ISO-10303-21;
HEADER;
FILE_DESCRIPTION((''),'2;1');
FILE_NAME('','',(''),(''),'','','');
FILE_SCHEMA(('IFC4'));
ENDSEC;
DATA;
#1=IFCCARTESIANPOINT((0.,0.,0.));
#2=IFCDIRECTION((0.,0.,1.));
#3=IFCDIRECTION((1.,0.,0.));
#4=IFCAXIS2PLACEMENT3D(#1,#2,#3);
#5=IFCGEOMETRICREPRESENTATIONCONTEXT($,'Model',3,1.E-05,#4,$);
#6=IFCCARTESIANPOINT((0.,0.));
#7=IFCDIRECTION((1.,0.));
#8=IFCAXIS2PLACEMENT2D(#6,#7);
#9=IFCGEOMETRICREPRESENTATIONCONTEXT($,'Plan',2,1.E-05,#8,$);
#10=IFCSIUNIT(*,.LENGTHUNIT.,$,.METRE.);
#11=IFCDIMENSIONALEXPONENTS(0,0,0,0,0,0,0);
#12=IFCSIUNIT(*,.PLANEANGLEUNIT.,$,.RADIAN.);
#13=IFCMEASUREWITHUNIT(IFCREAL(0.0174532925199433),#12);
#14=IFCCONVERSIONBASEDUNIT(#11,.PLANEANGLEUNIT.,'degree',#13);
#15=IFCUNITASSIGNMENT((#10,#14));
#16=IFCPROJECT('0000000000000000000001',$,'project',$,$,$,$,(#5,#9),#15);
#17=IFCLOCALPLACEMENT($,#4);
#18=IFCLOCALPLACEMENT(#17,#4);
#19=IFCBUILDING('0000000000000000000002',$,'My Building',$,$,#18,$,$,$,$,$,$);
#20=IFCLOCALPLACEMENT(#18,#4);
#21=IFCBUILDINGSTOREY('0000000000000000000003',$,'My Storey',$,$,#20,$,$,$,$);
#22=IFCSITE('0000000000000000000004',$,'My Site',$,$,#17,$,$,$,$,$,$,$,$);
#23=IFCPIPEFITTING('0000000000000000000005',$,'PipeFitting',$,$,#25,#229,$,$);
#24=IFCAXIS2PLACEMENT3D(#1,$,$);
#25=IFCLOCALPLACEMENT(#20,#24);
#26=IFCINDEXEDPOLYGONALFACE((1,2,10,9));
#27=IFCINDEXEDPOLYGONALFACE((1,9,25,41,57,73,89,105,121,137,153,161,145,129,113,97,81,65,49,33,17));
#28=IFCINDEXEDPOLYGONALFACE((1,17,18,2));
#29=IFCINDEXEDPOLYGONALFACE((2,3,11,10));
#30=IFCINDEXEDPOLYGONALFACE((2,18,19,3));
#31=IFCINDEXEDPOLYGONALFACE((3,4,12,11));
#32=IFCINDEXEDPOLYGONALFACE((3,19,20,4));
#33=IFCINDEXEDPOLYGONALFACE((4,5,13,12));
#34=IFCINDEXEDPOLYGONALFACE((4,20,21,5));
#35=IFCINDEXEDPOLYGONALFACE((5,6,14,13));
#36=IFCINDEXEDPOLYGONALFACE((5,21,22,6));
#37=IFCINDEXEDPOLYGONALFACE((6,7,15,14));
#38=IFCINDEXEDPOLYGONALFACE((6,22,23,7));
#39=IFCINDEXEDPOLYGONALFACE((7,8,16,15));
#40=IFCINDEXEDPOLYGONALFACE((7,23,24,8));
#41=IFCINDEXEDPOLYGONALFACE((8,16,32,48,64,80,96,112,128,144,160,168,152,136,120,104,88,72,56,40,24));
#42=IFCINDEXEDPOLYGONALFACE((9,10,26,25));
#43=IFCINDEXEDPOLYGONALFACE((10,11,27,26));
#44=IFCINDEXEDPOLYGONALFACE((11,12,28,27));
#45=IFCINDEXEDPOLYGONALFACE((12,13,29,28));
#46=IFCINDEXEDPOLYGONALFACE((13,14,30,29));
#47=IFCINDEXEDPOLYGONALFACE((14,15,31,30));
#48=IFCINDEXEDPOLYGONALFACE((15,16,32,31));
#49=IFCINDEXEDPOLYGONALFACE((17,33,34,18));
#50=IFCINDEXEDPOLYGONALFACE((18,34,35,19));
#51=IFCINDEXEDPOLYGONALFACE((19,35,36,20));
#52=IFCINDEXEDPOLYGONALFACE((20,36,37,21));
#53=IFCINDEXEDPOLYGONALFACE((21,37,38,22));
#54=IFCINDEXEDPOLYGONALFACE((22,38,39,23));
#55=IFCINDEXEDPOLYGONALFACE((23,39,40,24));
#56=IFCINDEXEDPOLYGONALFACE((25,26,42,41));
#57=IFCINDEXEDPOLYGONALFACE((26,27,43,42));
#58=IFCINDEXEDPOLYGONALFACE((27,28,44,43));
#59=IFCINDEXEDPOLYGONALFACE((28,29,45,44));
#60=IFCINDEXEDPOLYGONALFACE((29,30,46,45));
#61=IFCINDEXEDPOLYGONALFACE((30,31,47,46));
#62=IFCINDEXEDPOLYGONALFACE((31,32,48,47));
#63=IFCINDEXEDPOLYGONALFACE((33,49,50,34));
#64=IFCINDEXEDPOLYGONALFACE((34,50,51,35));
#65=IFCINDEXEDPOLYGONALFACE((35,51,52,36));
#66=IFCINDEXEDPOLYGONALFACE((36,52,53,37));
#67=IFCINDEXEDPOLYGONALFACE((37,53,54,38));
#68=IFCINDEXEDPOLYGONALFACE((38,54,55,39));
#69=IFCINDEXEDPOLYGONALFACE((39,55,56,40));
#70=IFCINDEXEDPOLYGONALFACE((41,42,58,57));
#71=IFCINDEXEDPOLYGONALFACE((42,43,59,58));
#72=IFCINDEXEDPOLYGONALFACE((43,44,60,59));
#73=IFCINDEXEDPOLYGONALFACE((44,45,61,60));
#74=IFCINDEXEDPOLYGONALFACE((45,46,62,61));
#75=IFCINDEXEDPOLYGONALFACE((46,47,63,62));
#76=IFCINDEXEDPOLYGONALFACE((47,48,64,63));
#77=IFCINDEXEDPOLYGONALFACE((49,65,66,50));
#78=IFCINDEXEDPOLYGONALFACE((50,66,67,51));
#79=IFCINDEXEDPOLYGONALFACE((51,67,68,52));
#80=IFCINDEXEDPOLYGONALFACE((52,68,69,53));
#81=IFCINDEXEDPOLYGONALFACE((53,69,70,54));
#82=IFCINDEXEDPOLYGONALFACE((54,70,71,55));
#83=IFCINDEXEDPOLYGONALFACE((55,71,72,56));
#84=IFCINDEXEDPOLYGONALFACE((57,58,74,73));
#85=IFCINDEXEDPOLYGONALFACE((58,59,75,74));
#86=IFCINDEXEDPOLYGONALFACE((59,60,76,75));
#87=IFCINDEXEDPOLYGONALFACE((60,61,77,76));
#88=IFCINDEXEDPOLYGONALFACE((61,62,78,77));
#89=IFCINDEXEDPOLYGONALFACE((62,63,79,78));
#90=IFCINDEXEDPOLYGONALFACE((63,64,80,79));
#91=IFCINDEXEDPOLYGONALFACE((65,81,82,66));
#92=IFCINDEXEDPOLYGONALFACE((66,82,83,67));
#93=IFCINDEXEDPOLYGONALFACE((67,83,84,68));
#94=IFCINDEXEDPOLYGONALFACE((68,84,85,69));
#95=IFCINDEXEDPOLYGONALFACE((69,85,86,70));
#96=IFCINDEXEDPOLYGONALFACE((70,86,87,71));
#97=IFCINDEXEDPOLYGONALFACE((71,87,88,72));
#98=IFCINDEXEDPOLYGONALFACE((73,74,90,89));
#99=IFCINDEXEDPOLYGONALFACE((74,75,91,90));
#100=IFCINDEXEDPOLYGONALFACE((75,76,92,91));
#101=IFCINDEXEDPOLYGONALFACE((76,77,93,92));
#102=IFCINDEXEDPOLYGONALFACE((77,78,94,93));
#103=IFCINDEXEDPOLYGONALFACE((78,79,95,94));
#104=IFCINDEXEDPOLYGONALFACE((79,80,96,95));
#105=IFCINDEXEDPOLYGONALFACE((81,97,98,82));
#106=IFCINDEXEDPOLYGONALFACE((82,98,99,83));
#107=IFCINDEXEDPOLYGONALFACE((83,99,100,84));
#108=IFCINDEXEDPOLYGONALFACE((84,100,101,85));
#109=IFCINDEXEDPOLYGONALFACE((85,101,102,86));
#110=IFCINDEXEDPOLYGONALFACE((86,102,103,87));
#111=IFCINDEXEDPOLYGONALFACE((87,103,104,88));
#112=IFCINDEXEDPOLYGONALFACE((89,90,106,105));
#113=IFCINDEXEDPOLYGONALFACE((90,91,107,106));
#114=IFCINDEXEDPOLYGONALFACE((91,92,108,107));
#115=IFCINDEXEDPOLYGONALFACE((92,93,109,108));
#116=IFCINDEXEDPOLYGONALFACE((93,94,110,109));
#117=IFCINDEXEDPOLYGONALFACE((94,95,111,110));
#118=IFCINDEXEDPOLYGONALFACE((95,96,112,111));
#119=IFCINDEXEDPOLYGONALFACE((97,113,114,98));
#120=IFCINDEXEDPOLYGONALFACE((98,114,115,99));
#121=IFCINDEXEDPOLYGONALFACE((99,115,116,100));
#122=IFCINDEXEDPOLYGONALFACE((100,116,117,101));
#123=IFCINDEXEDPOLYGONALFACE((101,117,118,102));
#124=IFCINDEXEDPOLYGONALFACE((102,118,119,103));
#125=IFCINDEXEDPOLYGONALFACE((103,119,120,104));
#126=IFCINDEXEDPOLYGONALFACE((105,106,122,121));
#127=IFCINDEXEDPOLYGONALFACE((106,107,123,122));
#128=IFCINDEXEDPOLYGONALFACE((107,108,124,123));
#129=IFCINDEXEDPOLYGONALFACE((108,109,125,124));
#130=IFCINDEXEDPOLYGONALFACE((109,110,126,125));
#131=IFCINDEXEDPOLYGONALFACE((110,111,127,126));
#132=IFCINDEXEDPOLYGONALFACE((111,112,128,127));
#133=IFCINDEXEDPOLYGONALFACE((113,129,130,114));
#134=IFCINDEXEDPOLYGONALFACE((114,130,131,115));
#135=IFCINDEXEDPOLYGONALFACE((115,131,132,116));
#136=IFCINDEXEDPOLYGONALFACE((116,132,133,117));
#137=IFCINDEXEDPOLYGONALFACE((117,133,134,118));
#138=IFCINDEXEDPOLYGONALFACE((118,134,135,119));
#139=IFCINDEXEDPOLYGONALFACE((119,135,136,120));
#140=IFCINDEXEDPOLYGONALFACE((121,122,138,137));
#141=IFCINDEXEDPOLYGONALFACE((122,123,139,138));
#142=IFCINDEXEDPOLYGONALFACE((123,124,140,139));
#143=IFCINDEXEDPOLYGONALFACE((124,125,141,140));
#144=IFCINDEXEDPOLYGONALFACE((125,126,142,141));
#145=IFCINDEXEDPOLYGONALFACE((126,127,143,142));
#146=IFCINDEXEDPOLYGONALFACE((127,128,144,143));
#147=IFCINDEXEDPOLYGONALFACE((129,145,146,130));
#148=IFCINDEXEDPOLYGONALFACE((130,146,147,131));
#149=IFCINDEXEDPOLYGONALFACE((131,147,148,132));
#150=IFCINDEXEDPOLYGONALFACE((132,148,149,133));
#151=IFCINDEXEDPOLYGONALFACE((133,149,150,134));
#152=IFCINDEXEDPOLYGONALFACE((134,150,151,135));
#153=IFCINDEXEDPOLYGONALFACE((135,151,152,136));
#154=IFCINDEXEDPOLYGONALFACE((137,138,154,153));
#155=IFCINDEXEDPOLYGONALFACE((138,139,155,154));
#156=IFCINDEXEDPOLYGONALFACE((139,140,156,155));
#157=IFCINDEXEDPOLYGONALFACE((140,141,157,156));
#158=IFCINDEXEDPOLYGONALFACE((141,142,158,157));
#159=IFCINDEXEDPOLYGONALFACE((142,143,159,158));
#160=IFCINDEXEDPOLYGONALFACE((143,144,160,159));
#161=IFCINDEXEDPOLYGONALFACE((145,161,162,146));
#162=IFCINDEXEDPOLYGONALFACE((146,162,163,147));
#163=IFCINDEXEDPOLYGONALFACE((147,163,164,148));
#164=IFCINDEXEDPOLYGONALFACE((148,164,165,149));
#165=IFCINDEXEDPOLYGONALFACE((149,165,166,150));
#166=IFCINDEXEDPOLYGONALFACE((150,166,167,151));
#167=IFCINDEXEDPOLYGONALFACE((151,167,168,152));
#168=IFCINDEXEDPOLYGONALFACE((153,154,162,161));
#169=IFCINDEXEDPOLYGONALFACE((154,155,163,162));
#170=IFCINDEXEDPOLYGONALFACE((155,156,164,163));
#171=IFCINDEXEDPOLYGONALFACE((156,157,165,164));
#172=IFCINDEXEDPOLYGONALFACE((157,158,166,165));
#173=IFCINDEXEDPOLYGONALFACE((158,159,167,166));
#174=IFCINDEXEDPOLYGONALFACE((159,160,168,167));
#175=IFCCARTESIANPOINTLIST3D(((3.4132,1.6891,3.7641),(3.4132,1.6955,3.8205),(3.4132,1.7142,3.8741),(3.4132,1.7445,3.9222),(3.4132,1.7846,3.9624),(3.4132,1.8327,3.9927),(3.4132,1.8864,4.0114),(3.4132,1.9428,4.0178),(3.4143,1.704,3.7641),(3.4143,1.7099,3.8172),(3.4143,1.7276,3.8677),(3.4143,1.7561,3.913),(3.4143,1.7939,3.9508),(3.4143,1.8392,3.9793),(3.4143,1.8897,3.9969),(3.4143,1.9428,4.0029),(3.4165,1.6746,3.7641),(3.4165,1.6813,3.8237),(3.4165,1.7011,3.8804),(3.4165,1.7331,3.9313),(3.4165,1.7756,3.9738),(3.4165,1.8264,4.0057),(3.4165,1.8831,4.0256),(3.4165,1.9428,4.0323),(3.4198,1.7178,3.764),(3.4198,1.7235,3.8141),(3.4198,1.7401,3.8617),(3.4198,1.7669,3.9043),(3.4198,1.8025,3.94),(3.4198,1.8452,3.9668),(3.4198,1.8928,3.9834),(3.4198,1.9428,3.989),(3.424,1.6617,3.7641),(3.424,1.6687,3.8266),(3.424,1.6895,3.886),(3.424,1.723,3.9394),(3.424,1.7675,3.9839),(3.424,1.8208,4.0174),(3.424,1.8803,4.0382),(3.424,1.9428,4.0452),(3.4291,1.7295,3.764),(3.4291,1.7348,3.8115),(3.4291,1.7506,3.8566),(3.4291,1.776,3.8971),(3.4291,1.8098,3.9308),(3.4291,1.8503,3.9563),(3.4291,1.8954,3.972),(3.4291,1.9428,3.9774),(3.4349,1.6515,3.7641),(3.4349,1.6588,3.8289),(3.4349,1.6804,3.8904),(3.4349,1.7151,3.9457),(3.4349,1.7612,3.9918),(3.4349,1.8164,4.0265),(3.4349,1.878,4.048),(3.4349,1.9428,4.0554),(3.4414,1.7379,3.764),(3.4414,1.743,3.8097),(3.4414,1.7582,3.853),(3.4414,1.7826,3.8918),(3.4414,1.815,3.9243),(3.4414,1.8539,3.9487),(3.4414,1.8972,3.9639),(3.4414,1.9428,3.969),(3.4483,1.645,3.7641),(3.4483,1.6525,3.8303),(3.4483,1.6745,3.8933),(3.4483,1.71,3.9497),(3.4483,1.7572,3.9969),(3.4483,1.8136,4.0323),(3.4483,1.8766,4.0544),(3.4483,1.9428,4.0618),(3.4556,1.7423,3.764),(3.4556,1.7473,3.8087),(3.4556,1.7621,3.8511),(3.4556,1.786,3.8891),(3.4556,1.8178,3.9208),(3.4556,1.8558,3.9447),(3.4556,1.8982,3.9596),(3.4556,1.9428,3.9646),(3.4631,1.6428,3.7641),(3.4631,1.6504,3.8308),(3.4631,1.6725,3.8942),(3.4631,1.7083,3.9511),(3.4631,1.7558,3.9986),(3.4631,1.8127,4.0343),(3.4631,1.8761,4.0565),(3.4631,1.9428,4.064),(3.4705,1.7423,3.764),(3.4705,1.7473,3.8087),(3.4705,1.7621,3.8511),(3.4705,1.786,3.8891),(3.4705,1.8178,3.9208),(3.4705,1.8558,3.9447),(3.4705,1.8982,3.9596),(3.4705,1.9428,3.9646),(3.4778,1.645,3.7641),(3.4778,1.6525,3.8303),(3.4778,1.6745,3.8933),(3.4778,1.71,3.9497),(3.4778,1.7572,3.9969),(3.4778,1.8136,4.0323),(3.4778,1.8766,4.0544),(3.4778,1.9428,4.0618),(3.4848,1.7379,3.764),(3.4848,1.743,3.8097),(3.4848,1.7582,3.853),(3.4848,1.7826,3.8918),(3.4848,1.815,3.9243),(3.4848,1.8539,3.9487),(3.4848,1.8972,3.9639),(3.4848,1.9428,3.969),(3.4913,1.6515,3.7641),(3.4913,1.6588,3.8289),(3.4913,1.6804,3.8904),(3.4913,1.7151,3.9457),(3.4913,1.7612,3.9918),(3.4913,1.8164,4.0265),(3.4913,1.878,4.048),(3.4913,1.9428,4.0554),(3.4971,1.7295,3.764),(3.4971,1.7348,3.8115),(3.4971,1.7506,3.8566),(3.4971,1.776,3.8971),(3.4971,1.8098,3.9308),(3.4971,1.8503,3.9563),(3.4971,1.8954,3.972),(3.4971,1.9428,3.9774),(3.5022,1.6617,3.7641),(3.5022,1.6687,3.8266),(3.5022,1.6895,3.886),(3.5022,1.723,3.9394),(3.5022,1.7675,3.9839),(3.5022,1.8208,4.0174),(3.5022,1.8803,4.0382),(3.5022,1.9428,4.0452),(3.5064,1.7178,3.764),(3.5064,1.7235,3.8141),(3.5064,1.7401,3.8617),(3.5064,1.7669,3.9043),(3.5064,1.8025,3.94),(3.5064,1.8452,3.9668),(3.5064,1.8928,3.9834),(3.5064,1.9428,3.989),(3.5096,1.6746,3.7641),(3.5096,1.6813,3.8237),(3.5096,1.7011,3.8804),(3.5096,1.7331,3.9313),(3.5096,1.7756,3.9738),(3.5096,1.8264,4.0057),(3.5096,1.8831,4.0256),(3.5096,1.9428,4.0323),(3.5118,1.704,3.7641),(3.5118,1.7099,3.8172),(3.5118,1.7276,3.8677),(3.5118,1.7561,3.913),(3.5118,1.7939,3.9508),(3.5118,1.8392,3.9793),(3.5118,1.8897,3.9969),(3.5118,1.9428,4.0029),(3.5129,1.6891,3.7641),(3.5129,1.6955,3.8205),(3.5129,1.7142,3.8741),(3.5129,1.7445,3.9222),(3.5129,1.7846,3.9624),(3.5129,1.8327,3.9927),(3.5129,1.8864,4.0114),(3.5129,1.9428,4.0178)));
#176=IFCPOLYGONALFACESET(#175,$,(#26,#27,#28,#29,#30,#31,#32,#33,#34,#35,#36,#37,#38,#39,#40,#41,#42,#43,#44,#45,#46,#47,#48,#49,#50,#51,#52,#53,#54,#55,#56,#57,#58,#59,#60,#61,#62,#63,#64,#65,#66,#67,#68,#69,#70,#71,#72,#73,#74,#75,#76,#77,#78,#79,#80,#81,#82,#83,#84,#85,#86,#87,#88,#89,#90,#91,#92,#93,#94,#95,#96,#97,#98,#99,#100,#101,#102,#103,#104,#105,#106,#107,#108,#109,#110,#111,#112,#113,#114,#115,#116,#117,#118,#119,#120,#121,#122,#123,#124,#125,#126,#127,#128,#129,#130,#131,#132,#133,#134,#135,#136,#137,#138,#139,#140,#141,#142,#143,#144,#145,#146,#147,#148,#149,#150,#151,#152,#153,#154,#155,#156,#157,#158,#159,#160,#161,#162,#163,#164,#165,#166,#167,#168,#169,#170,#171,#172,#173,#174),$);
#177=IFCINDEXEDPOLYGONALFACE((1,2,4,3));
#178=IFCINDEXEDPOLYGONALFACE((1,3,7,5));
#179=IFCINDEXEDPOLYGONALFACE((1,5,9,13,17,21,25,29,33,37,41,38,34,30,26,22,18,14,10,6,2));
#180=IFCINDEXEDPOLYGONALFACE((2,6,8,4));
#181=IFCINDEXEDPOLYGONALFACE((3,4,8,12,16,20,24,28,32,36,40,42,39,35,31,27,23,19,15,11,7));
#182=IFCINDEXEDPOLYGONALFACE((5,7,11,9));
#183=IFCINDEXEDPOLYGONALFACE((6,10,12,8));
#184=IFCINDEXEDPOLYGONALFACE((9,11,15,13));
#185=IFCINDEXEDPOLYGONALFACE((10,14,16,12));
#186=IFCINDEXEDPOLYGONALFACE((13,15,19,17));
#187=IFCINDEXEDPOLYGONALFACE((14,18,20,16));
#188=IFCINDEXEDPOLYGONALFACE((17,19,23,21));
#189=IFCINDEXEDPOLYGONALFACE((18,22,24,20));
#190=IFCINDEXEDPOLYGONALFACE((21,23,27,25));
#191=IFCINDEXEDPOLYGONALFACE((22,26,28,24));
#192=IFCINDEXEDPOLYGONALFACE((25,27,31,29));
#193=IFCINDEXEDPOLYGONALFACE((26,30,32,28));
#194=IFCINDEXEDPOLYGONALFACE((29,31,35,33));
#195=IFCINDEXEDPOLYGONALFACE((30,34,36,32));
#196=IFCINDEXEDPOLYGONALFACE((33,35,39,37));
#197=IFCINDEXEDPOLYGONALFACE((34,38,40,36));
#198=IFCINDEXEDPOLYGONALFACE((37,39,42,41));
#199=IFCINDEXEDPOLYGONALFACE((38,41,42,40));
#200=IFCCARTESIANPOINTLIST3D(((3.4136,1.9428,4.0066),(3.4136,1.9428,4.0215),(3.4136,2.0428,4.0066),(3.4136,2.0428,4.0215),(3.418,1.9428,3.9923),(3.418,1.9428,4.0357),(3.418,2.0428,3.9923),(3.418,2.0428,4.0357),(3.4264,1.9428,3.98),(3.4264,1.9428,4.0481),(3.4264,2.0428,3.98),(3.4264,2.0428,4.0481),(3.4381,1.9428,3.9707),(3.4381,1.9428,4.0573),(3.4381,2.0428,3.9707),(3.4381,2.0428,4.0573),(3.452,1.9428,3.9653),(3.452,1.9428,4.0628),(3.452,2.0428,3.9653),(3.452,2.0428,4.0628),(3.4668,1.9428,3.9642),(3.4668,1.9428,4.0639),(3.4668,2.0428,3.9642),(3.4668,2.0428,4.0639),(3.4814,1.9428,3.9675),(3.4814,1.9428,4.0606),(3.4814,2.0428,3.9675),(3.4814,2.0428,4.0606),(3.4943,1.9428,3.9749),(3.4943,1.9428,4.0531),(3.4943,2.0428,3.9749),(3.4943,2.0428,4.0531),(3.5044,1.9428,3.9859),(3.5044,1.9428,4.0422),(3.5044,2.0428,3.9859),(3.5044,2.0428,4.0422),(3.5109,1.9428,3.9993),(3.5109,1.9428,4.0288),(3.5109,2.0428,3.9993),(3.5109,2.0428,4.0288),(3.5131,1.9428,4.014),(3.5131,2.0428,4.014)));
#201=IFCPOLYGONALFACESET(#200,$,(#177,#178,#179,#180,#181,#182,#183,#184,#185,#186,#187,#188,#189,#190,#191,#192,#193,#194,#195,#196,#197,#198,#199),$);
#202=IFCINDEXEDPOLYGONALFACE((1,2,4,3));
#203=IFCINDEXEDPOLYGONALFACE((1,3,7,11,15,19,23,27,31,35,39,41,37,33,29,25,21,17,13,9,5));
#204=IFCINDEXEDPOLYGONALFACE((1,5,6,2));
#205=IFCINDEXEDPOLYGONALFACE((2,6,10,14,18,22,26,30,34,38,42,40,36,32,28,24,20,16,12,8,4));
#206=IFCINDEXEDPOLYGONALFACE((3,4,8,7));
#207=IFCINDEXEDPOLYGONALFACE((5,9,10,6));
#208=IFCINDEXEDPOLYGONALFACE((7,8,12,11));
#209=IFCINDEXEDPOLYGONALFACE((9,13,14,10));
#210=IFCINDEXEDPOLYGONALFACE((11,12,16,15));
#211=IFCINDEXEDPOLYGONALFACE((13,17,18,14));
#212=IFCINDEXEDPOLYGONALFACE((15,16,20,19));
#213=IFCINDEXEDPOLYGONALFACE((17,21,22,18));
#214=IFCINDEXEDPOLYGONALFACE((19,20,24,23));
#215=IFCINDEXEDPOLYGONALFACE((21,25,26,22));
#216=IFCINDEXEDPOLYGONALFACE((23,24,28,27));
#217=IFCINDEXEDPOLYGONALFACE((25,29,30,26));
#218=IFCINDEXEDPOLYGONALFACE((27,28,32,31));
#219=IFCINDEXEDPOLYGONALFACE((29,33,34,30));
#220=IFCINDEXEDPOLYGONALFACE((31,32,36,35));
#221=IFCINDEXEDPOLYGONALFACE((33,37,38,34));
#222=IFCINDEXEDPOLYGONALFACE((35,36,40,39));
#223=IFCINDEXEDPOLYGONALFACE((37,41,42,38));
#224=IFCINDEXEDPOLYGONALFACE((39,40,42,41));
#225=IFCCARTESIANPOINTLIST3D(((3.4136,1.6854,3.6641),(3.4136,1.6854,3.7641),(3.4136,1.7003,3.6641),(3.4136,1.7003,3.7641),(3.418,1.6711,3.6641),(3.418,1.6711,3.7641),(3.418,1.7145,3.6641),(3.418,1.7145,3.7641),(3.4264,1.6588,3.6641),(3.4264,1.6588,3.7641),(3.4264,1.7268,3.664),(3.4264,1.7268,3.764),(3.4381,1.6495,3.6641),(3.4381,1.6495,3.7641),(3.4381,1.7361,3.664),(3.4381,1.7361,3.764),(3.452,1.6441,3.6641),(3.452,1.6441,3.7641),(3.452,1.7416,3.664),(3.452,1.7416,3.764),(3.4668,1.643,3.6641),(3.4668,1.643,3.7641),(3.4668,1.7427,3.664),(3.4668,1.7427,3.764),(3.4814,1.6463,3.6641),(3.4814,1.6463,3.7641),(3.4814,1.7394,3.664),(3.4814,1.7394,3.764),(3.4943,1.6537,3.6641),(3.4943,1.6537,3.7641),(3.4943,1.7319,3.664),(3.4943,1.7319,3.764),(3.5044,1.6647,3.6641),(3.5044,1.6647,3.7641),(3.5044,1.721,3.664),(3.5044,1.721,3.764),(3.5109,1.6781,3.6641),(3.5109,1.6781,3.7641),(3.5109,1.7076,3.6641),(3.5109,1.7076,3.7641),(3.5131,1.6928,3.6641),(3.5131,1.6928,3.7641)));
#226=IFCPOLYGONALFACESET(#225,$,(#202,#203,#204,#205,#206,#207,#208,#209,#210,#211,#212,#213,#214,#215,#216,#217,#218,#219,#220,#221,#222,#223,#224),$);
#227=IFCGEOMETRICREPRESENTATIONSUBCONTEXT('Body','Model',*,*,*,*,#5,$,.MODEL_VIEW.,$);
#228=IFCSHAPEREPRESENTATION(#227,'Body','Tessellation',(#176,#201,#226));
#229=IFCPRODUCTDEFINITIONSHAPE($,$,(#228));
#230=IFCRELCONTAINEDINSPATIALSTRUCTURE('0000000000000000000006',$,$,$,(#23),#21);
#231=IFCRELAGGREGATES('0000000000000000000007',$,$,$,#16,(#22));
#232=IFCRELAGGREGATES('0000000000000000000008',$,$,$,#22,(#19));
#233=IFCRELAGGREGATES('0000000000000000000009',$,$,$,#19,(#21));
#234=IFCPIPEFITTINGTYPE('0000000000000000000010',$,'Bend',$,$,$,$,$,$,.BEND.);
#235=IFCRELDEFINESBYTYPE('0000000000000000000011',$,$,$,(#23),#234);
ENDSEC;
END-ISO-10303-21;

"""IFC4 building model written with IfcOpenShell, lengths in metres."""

from ifc_helpers import new_model, entity, si_unit, converted_unit, frame, origin_with_axes, origin_2d_with_axis, place, context, subcontext, project, spatial, circle, extrude, source, transform, mapped, type_object, type_shapes, element, save


model = new_model("IFC4")

# Units and contexts
model_context = context("Model", 3, precision=1e-05, world=origin_with_axes())
plan_context = context("Plan", 2, precision=1e-05, world=origin_2d_with_axis())
body_context = subcontext(model_context, "Body", "Model", "MODEL_VIEW")
ifc_project = project(units=[si_unit("LENGTHUNIT", "METRE"), converted_unit("PLANEANGLEUNIT", "degree", entity("IfcReal", 0.0174532925199433), si_unit("PLANEANGLEUNIT", "RADIAN"), dimensions=[0, 0, 0, 0, 0, 0, 0])], contexts=[model_context, plan_context])

# Site, building, storey
site_placement = place(None, origin_with_axes())
site = spatial("IfcSite", under=ifc_project, at=site_placement, Name="My Site")
building_placement = place(site_placement, origin_with_axes())
building = spatial("IfcBuilding", under=site, at=building_placement, Name="My Building")
storey_placement = place(building_placement, origin_with_axes())
storey = spatial("IfcBuildingStorey", under=building, at=storey_placement, Name="My Storey")

# Pipe fitting
pipe_fitting_type_1 = type_object("IfcPipeFittingType", Name="Bend", PredefinedType="BEND")
shared_shape_1 = source(origin_with_axes(), body_context, "Body", "SolidModel", [
    entity("IfcSweptDiskSolid", entity("IfcIndexedPolyCurve", entity("IfcCartesianPointList3D", [[0.0, 0.0, 0.1], [0.0, -0.0732, 0.2768], [0.0, -0.25, 0.35]]), [entity("IfcArcIndex", [1, 2, 3])]), 0.05),
    extrude(circle(Radius=0.05), origin_with_axes(), (0.0, 0.0, 1.0), 0.1),
    extrude(circle(Radius=0.05), frame((0.0, -0.25, 0.35), z_axis=(0.0, -1.0, 0.000038), x_axis=(1.0, 0.0, 0.0)), (0.0, 0.0, 1.0), 0.1),
])
type_shapes(pipe_fitting_type_1, [shared_shape_1])
for number, where, z_axis, x_axis, name in (
    (1, (3.4631, 2.0428, 4.014), (0.0, -1.0, 0.0), (1.0, 0.0, 0.0), "PipeFitting"),
):
    element("IfcPipeFitting", number, at=place(storey_placement, frame(where, z_axis=z_axis, x_axis=x_axis)), inside=storey, type_object=pipe_fitting_type_1, Name=name, context=body_context, shape_type="MappedRepresentation", body=[
        mapped(shared_shape_1, transform((0.0, 0.0, 0.0), x_axis=(1.0, 0.0, 0.0), y_axis=(0.0, 1.0, 0.0), z_axis=(0.0, 0.0, 1.0), scale=1.0)),
    ])

save(model, "model.ifc")
